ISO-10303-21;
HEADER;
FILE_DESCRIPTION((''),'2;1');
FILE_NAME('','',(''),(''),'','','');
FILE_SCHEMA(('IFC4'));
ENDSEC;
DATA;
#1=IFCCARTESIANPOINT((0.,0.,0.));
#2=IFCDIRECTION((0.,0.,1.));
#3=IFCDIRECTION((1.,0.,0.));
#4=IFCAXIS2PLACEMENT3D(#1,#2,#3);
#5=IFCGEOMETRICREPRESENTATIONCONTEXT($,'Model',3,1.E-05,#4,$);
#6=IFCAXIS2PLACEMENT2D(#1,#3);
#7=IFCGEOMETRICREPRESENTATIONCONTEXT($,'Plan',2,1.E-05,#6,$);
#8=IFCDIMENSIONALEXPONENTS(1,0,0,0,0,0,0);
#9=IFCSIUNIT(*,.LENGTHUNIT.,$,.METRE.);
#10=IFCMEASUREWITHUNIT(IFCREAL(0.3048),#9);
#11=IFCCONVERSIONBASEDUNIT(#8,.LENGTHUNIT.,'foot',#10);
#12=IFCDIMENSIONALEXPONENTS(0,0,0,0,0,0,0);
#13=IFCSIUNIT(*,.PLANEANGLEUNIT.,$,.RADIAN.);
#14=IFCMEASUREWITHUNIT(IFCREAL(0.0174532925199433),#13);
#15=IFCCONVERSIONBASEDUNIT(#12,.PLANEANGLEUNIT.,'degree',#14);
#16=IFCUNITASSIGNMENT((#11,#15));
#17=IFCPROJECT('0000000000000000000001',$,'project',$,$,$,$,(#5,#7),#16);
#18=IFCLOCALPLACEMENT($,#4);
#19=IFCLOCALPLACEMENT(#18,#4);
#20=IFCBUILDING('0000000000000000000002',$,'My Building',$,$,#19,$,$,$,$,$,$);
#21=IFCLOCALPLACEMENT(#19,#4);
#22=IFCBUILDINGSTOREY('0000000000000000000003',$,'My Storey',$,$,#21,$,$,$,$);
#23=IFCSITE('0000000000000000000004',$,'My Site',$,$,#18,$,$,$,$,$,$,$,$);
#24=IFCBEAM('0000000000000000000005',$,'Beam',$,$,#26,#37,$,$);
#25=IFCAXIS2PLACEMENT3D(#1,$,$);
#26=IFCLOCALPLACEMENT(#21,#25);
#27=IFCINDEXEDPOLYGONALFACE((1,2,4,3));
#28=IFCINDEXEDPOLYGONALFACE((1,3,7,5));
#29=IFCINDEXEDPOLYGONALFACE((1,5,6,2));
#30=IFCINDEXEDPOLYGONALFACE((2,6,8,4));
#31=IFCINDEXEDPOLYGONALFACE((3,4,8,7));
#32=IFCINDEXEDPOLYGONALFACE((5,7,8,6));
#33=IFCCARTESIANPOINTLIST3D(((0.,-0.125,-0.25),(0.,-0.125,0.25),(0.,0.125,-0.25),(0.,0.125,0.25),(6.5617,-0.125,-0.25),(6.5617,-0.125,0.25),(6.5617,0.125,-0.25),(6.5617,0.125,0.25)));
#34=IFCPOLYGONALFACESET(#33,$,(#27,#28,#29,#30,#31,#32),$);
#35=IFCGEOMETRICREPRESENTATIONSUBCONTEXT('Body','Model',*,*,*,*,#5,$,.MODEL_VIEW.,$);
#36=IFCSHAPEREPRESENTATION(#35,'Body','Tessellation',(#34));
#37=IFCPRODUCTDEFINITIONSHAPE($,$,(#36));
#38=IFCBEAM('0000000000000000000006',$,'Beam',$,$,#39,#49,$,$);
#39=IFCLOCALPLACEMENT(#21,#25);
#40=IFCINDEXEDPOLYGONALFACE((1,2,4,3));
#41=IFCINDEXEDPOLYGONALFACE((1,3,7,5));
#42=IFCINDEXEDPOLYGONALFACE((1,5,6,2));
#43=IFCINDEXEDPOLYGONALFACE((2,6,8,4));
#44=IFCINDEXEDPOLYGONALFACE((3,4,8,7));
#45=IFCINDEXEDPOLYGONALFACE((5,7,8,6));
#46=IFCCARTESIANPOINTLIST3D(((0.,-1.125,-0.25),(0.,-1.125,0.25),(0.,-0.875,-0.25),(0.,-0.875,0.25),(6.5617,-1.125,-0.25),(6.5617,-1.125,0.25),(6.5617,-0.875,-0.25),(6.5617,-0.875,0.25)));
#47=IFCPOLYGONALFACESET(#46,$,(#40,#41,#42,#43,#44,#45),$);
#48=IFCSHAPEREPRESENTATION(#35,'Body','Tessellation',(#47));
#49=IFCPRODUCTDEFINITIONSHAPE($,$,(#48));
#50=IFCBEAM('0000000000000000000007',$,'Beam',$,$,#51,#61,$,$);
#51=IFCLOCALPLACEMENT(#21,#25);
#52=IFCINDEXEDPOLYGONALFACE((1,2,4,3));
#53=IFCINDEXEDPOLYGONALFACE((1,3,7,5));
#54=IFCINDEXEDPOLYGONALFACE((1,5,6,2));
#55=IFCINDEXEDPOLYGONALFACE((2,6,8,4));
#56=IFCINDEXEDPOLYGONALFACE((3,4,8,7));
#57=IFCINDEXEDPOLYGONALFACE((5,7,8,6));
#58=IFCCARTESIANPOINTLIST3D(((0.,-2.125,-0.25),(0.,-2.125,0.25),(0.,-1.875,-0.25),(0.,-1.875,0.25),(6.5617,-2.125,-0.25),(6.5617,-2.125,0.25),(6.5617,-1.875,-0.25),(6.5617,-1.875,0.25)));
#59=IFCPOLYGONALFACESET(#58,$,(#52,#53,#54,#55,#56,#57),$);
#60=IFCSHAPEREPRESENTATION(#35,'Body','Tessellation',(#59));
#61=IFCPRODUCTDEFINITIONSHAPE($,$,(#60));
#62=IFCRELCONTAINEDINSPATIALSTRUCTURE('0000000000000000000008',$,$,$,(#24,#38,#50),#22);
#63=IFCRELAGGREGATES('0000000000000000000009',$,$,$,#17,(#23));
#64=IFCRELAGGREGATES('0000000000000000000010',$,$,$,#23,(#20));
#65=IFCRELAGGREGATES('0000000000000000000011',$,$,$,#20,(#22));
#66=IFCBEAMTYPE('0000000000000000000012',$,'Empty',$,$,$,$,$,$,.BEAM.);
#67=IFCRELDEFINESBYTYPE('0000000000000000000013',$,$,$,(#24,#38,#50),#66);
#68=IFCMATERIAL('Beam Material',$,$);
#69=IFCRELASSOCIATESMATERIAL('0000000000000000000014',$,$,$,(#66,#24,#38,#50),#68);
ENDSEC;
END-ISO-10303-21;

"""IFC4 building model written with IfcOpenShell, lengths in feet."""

from ifc_helpers import new_model, entity, si_unit, converted_unit, frame, frame_2d, origin_with_axes, place, context, subcontext, project, spatial, rectangle, extrude, material, material_profile, profile_set, profile_usage, type_object, element, save


model = new_model("IFC4")

# Units and contexts
model_context = context("Model", 3, precision=1e-05, world=origin_with_axes())
plan_context = context("Plan", 2, precision=1e-05, world=frame_2d((0.0, 0.0, 0.0), x_axis=(1.0, 0.0, 0.0)))
body_context = subcontext(model_context, "Body", "Model", "MODEL_VIEW")
ifc_project = project(units=[converted_unit("LENGTHUNIT", "foot", entity("IfcReal", 0.3048), si_unit("LENGTHUNIT", "METRE"), dimensions=[1, 0, 0, 0, 0, 0, 0]), converted_unit("PLANEANGLEUNIT", "degree", entity("IfcReal", 0.0174532925199433), si_unit("PLANEANGLEUNIT", "RADIAN"), dimensions=[0, 0, 0, 0, 0, 0, 0])], contexts=[model_context, plan_context])

# Site, building, storey
site_placement = place(None, origin_with_axes())
site = spatial("IfcSite", under=ifc_project, at=site_placement, Name="My Site")
building_placement = place(site_placement, origin_with_axes())
building = spatial("IfcBuilding", under=site, at=building_placement, Name="My Building")
storey_placement = place(building_placement, origin_with_axes())
storey = spatial("IfcBuildingStorey", under=building, at=storey_placement, Name="My Storey")

# Beams
ifc_material = material(Name="Beam Material")
ifc_material_profile = material_profile(ifc_material, rectangle(XDim=0.25, YDim=0.5))
ifc_profile_set = profile_set([ifc_material_profile])
ifc_profile_usage_1 = profile_usage(ifc_profile_set)
beam_type = type_object("IfcBeamType", Name="Empty", PredefinedType="BEAM", material=ifc_profile_set)
beam_1_placement = place(storey_placement, frame((0.0, 0.0, 0.0), z_axis=(1.0, 0.0, 0.0), x_axis=(0.0, 1.0, 0.0)))
element("IfcBeam", 1, at=beam_1_placement, inside=storey, type_object=beam_type, material=ifc_profile_usage_1, Name="Beam", context=body_context, shape_type="SweptSolid", body=[
    extrude(rectangle(XDim=0.25, YDim=0.5), None, (0.0, 0.0, 1.0), 6.5617),
])
ifc_profile_usage_2 = profile_usage(ifc_profile_set)
beam_2_placement = place(storey_placement, frame((0.0, -1.0, 0.0), z_axis=(1.0, 0.0, 0.0), x_axis=(0.0, 1.0, 0.0)))
element("IfcBeam", 2, at=beam_2_placement, inside=storey, type_object=beam_type, material=ifc_profile_usage_2, Name="Beam", context=body_context, shape_type="SweptSolid", body=[
    extrude(rectangle(XDim=0.25, YDim=0.5), None, (0.0, 0.0, 1.0), 6.5617),
])
ifc_profile_usage_3 = profile_usage(ifc_profile_set)
beam_3_placement = place(storey_placement, frame((0.0, -2.0, 0.0), z_axis=(1.0, 0.0, 0.0), x_axis=(0.0, 1.0, 0.0)))
element("IfcBeam", 3, at=beam_3_placement, inside=storey, type_object=beam_type, material=ifc_profile_usage_3, Name="Beam", context=body_context, shape_type="SweptSolid", body=[
    extrude(rectangle(XDim=0.25, YDim=0.5), None, (0.0, 0.0, 1.0), 6.5617),
])

save(model, "model.ifc")
